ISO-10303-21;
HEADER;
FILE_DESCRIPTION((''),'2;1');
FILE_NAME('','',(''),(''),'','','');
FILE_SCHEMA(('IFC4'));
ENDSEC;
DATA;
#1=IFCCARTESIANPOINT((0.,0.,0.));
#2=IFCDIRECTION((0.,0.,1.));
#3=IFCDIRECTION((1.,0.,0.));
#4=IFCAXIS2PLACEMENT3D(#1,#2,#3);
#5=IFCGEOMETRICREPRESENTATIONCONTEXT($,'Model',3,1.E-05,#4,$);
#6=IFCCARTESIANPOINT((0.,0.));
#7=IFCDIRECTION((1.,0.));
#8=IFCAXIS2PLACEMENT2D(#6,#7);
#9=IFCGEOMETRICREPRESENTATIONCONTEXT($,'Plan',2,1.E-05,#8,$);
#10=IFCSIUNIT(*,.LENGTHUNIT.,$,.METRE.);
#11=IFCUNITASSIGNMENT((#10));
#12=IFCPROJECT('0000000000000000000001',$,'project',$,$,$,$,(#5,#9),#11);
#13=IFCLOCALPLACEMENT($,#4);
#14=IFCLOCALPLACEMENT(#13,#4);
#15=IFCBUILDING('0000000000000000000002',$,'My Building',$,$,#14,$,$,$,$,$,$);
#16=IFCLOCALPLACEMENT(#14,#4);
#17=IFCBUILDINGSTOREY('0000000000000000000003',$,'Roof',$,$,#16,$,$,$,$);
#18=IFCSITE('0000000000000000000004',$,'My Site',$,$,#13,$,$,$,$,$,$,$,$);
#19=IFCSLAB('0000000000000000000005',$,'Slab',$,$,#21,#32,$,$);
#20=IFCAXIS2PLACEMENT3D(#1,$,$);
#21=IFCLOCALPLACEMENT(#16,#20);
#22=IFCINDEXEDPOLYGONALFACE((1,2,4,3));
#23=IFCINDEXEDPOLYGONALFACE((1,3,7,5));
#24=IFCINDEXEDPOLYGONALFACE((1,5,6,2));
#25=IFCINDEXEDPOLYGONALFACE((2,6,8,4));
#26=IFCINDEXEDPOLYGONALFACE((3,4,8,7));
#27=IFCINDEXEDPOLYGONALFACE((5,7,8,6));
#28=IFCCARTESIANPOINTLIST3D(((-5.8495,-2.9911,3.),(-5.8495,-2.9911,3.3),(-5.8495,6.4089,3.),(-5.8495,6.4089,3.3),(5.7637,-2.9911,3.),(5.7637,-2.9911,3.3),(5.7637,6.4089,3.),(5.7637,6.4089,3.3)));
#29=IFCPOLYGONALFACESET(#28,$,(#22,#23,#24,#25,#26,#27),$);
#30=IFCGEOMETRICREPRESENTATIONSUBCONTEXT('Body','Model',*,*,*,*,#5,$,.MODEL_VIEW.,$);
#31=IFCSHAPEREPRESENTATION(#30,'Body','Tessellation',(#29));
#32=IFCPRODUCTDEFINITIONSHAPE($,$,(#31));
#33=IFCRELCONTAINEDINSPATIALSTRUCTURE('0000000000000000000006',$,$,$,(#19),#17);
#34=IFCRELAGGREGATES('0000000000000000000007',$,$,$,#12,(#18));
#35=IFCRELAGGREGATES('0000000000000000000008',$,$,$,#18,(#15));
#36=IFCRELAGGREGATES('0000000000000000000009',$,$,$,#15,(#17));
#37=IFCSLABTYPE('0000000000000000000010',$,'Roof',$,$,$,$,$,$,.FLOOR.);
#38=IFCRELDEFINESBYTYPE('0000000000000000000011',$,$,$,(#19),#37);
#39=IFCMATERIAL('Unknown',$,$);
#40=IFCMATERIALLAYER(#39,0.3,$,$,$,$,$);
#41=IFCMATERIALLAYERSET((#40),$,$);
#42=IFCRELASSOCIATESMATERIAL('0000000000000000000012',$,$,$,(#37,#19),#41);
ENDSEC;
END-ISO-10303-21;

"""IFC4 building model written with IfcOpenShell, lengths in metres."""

from ifc_helpers import new_model, si_unit, frame, origin_with_axes, origin_2d_with_axis, place, context, subcontext, project, spatial, indexed_curve, outline, extrude, material, layer, layer_set, layer_usage, type_object, element, save


model = new_model("IFC4")

# Units and contexts
model_context = context("Model", 3, precision=1e-05, world=origin_with_axes())
plan_context = context("Plan", 2, precision=1e-05, world=origin_2d_with_axis())
body_context = subcontext(model_context, "Body", "Model", "MODEL_VIEW")
ifc_project = project(units=[si_unit("LENGTHUNIT", "METRE")], contexts=[model_context, plan_context])

# Site, building, storey
site_placement = place(None, origin_with_axes())
site = spatial("IfcSite", under=ifc_project, at=site_placement, Name="My Site")
building_placement = place(site_placement, origin_with_axes())
building = spatial("IfcBuilding", under=site, at=building_placement, Name="My Building")
storey_placement = place(building_placement, origin_with_axes())
storey = spatial("IfcBuildingStorey", under=building, at=storey_placement, Name="Roof")

# Slab
ifc_material = material(Name="Unknown")
ifc_layer = layer(ifc_material, 0.3)
ifc_layer_set = layer_set([ifc_layer])
ifc_layer_usage = layer_usage(ifc_layer_set, "AXIS3", "POSITIVE", -0.3)
slab_type = type_object("IfcSlabType", Name="Roof", PredefinedType="FLOOR", material=ifc_layer_set)
slab_placement = place(storey_placement, frame((5.7637, -2.9911, 3.3), z_axis=(0.0, 0.0, 1.0), x_axis=(1.0, 0.0, 0.0)))
element("IfcSlab", 1, at=slab_placement, inside=storey, type_object=slab_type, material=ifc_layer_usage, Name="Slab", context=body_context, shape_type="SweptSolid", body=[
    extrude(outline(indexed_curve([(0.0, 0.0), (0.0, 9.4), (-11.6132, 9.4), (-11.6132, 0.0), (0.0, 0.0)])), frame((0.0, 0.0, -0.3), z_axis=(0.0, 0.0, 1.0), x_axis=(1.0, 0.0, 0.0)), (0.0, 0.0, 1.0), 0.3),
])

save(model, "model.ifc")
